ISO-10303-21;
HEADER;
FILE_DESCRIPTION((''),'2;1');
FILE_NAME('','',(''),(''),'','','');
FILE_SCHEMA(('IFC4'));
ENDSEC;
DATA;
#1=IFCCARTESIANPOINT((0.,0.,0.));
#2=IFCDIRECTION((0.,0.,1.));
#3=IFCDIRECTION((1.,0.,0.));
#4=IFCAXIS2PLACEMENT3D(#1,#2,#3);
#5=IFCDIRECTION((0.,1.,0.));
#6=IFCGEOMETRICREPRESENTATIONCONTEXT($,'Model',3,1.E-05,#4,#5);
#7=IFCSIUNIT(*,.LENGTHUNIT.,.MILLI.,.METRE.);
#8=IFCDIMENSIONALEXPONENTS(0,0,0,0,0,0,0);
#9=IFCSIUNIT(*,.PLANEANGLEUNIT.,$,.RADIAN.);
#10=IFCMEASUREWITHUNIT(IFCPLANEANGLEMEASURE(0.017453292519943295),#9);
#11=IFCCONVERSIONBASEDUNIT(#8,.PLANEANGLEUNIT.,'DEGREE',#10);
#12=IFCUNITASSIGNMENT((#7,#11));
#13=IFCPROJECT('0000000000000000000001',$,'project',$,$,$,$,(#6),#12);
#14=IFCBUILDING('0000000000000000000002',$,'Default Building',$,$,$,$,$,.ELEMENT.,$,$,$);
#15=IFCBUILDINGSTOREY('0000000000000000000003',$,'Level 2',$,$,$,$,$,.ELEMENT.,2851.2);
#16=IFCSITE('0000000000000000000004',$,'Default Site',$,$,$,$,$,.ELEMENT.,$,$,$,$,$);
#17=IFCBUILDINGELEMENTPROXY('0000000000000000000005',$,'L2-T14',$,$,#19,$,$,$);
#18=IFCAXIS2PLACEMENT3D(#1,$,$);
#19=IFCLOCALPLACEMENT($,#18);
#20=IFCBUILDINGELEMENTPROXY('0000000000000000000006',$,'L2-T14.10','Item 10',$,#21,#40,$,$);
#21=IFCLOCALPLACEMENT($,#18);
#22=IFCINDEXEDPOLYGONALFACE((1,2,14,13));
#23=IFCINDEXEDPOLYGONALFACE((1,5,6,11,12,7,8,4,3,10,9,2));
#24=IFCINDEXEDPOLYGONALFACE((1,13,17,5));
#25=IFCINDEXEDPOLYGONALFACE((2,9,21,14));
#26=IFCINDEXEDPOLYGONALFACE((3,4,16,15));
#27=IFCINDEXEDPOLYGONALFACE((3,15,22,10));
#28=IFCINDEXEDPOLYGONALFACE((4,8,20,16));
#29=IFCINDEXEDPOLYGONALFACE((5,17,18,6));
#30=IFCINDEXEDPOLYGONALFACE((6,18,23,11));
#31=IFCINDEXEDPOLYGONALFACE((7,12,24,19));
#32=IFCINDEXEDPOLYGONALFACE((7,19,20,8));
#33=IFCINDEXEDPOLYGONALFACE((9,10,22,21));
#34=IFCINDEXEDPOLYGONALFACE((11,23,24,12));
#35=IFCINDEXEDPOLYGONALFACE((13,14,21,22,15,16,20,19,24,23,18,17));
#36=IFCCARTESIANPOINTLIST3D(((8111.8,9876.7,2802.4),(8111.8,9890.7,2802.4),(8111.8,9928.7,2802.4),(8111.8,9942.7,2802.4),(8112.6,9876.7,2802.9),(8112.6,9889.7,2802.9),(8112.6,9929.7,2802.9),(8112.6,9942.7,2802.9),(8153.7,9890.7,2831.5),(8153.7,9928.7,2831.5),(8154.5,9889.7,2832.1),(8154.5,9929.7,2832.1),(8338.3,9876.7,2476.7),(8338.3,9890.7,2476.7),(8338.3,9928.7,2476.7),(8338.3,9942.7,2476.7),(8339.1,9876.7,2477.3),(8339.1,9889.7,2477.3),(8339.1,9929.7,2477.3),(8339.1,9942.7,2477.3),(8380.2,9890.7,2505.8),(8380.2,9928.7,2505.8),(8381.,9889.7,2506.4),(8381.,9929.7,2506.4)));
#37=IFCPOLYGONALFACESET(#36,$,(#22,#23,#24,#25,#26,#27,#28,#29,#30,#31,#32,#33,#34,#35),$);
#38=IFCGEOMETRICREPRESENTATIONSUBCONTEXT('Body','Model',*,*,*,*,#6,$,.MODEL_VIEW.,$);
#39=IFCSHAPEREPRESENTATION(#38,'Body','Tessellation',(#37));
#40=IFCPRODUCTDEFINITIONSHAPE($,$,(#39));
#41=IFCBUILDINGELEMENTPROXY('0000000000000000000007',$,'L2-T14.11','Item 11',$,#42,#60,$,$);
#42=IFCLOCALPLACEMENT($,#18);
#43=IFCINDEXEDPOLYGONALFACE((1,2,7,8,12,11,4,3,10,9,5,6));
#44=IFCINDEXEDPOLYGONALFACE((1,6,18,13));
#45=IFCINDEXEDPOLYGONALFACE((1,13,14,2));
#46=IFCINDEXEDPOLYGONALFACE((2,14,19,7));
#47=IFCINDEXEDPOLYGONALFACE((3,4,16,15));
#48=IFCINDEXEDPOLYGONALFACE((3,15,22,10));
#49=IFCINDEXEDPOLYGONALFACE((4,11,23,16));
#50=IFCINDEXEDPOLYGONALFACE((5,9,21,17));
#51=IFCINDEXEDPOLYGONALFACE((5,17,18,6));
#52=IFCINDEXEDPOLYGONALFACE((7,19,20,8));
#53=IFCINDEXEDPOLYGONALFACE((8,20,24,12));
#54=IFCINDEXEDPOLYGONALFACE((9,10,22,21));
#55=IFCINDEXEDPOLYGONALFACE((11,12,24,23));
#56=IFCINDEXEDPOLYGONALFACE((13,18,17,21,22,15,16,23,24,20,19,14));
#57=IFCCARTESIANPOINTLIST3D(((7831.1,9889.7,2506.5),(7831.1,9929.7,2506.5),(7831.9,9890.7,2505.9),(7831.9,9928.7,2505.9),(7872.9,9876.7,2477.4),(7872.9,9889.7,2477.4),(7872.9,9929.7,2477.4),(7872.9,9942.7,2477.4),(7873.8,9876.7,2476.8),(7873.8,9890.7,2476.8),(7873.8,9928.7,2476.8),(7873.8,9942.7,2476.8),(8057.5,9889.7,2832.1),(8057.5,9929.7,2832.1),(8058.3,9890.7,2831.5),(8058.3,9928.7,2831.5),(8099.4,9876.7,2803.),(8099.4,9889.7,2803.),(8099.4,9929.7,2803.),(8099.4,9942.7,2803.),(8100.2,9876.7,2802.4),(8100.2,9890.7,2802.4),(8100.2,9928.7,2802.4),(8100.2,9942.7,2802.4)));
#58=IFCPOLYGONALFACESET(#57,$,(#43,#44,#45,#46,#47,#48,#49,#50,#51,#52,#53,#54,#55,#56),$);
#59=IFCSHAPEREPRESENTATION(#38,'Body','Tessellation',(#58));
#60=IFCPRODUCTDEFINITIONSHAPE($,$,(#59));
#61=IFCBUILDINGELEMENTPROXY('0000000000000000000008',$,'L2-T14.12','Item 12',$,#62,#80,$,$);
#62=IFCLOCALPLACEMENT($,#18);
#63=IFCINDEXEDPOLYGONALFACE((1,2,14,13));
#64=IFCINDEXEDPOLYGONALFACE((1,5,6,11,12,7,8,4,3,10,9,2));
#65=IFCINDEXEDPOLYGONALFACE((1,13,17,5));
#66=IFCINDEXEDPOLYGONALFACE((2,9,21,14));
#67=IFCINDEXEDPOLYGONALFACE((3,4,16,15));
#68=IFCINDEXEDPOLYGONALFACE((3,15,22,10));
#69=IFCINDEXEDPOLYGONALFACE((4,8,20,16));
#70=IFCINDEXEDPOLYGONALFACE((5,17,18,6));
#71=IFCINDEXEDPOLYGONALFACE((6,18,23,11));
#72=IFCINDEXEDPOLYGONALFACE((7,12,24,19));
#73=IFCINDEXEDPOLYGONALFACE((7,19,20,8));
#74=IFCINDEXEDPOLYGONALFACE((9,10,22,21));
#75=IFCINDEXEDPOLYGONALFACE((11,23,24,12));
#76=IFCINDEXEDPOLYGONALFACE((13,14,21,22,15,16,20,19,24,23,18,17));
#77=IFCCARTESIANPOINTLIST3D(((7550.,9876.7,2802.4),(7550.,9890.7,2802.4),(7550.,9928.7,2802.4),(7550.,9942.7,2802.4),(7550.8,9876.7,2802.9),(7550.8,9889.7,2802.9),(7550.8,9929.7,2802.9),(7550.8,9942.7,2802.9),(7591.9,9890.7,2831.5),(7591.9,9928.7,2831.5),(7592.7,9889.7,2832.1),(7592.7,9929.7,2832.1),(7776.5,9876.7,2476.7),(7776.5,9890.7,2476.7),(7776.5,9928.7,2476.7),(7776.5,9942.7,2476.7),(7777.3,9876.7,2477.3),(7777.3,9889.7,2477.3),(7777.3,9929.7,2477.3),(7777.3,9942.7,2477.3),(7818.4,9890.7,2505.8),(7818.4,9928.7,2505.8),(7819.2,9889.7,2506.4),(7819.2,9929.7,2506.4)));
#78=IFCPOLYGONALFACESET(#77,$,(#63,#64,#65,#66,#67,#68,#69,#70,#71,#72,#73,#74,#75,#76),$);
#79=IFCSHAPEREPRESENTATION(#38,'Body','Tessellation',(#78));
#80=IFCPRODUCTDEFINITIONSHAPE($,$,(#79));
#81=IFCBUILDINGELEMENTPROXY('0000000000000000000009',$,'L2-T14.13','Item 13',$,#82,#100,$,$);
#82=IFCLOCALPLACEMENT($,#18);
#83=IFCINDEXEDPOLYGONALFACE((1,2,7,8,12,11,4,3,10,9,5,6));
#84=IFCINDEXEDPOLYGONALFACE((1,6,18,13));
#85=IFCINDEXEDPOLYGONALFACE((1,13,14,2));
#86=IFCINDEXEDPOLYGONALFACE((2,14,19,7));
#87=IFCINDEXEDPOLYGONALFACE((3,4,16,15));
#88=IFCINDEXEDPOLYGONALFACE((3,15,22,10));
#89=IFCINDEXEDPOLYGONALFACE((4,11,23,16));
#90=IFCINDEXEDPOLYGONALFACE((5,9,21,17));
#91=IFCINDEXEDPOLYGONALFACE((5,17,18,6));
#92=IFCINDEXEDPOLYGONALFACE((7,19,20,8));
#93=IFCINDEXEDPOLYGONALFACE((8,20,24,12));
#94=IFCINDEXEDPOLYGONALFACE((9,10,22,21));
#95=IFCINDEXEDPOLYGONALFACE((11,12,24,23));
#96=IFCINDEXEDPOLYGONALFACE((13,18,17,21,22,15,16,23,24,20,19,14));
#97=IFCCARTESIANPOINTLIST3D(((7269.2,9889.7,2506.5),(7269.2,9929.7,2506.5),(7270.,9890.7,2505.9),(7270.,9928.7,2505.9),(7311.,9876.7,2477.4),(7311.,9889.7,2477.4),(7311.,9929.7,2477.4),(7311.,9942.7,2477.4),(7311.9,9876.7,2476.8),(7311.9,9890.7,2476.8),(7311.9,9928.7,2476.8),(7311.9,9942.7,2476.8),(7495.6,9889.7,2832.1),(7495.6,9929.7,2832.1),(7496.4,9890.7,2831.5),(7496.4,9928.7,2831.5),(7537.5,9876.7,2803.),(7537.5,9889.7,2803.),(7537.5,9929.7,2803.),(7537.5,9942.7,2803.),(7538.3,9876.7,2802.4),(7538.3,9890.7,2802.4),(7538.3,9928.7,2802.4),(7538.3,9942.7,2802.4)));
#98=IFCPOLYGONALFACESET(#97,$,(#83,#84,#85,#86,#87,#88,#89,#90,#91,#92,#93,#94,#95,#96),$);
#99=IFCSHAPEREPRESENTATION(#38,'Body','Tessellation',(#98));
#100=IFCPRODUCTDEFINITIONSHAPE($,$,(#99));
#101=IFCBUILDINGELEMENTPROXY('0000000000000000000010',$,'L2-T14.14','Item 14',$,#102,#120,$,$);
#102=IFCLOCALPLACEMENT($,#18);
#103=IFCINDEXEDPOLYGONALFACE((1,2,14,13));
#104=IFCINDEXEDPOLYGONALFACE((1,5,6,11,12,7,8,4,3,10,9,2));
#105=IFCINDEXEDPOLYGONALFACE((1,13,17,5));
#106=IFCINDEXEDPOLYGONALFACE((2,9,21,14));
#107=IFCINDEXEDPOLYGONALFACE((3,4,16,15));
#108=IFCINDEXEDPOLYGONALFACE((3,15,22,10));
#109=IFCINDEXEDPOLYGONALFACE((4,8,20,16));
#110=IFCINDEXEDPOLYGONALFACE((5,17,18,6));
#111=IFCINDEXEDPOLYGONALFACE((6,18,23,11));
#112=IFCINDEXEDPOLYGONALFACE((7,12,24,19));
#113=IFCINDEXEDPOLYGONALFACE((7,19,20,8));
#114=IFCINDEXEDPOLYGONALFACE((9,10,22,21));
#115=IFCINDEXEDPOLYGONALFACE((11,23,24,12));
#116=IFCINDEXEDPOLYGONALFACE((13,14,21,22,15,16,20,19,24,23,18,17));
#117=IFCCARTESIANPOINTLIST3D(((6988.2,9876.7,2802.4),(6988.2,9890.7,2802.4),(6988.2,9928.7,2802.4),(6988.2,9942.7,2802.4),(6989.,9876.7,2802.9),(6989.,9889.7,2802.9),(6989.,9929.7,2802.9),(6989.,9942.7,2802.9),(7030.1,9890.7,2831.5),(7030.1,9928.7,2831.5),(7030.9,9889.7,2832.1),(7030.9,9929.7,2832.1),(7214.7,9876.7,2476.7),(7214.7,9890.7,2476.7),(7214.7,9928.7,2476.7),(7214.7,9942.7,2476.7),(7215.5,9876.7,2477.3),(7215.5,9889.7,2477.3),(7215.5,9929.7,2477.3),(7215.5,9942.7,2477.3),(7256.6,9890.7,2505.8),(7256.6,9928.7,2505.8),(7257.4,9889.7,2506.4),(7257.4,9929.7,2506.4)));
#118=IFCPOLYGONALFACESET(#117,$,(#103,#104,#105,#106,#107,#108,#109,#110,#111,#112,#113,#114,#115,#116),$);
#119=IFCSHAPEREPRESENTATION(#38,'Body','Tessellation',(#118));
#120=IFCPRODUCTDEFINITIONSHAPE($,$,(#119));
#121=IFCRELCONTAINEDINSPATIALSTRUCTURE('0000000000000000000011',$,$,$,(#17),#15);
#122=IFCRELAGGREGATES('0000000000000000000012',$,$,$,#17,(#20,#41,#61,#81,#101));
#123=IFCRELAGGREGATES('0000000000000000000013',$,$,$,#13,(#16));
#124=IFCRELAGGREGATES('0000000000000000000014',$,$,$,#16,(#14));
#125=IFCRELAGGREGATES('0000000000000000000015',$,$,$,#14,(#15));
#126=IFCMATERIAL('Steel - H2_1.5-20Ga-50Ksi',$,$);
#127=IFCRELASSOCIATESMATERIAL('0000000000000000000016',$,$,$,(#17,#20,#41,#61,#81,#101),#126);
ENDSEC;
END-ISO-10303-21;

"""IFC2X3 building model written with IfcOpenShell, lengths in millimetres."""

from ifc_helpers import new_model, entity, si_unit, converted_unit, direction, frame, origin, origin_with_axes, place, context, subcontext, project, spatial, polyline, outline, extrude, material, element, aggregate, save


model = new_model("IFC2X3")

# Units and contexts
model_context = context("Model", 3, precision=1e-05, world=origin_with_axes(), true_north=direction((0.0, 1.0, 0.0)))
body_context = subcontext(model_context, "Body", "Model", "MODEL_VIEW")
ifc_project = project(units=[si_unit("LENGTHUNIT", "METRE", prefix="MILLI"), converted_unit("PLANEANGLEUNIT", "DEGREE", entity("IfcPlaneAngleMeasure", 0.017453292519943295), si_unit("PLANEANGLEUNIT", "RADIAN"), dimensions=[0, 0, 0, 0, 0, 0, 0])], contexts=[model_context])

# Site, building, storey
site = spatial("IfcSite", under=ifc_project, Name="Default Site", CompositionType="ELEMENT")
building = spatial("IfcBuilding", under=site, Name="Default Building", CompositionType="ELEMENT")
storey = spatial("IfcBuildingStorey", under=building, Name="Level 2", CompositionType="ELEMENT", Elevation=2851.2)

# Building element proxies
ifc_material_1 = material(Name="Steel - H2_1.5-20Ga-50Ksi")
proxy_1 = element("IfcBuildingElementProxy", 1, inside=storey, material=ifc_material_1, Name="L2-T14")
proxy_2_placement = place(None, frame((8338.3, 9942.7, 2476.7), z_axis=(-0.571, 0.0, 0.821), x_axis=(0.0, -40.0, 0.0)))
proxy_2 = element("IfcBuildingElementProxy", 2, at=proxy_2_placement, material=ifc_material_1, Name="L2-T14.10", Description="Item 10", context=body_context, shape_type="SweptSolid", body=[
    extrude(outline(polyline([(0.0, 0.0), (14.0, 0.0), (14.0, 51.0), (52.0, 51.0), (52.0, 0.0), (66.0, 0.0), (66.0, 1.0), (53.0, 1.0), (53.0, 52.0), (13.0, 52.0), (13.0, 1.0), (0.0, 1.0), (0.0, 0.0)])), origin(), (0.0, 0.0, 1.0), 396.7),
])
proxy_3_placement = place(None, frame((8100.2, 9942.7, 2802.4), z_axis=(-0.571, 0.0, -0.821), x_axis=(0.0, -40.0, 0.0)))
proxy_3 = element("IfcBuildingElementProxy", 3, at=proxy_3_placement, material=ifc_material_1, Name="L2-T14.11", Description="Item 11", context=body_context, shape_type="SweptSolid", body=[
    extrude(outline(polyline([(0.0, 0.0), (14.0, 0.0), (14.0, 51.0), (52.0, 51.0), (52.0, 0.0), (66.0, 0.0), (66.0, 1.0), (53.0, 1.0), (53.0, 52.0), (13.0, 52.0), (13.0, 1.0), (0.0, 1.0), (0.0, 0.0)])), origin(), (0.0, 0.0, 1.0), 396.6),
])
proxy_4_placement = place(None, frame((7776.5, 9942.7, 2476.7), z_axis=(-0.571, 0.0, 0.821), x_axis=(0.0, -40.0, 0.0)))
proxy_4 = element("IfcBuildingElementProxy", 4, at=proxy_4_placement, material=ifc_material_1, Name="L2-T14.12", Description="Item 12", context=body_context, shape_type="SweptSolid", body=[
    extrude(outline(polyline([(0.0, 0.0), (14.0, 0.0), (14.0, 51.0), (52.0, 51.0), (52.0, 0.0), (66.0, 0.0), (66.0, 1.0), (53.0, 1.0), (53.0, 52.0), (13.0, 52.0), (13.0, 1.0), (0.0, 1.0), (0.0, 0.0)])), origin(), (0.0, 0.0, 1.0), 396.7),
])
proxy_5_placement = place(None, frame((7538.3, 9942.7, 2802.4), z_axis=(-0.571, 0.0, -0.821), x_axis=(0.0, -40.0, 0.0)))
proxy_5 = element("IfcBuildingElementProxy", 5, at=proxy_5_placement, material=ifc_material_1, Name="L2-T14.13", Description="Item 13", context=body_context, shape_type="SweptSolid", body=[
    extrude(outline(polyline([(0.0, 0.0), (14.0, 0.0), (14.0, 51.0), (52.0, 51.0), (52.0, 0.0), (66.0, 0.0), (66.0, 1.0), (53.0, 1.0), (53.0, 52.0), (13.0, 52.0), (13.0, 1.0), (0.0, 1.0), (0.0, 0.0)])), origin(), (0.0, 0.0, 1.0), 396.6),
])
proxy_6_placement = place(None, frame((7214.7, 9942.7, 2476.7), z_axis=(-0.571, 0.0, 0.821), x_axis=(0.0, -40.0, 0.0)))
proxy_6 = element("IfcBuildingElementProxy", 6, at=proxy_6_placement, material=ifc_material_1, Name="L2-T14.14", Description="Item 14", context=body_context, shape_type="SweptSolid", body=[
    extrude(outline(polyline([(0.0, 0.0), (14.0, 0.0), (14.0, 51.0), (52.0, 51.0), (52.0, 0.0), (66.0, 0.0), (66.0, 1.0), (53.0, 1.0), (53.0, 52.0), (13.0, 52.0), (13.0, 1.0), (0.0, 1.0), (0.0, 0.0)])), origin(), (0.0, 0.0, 1.0), 396.7),
])
aggregate(proxy_1, [proxy_2, proxy_3, proxy_4, proxy_5, proxy_6])

save(model, "model.ifc")
